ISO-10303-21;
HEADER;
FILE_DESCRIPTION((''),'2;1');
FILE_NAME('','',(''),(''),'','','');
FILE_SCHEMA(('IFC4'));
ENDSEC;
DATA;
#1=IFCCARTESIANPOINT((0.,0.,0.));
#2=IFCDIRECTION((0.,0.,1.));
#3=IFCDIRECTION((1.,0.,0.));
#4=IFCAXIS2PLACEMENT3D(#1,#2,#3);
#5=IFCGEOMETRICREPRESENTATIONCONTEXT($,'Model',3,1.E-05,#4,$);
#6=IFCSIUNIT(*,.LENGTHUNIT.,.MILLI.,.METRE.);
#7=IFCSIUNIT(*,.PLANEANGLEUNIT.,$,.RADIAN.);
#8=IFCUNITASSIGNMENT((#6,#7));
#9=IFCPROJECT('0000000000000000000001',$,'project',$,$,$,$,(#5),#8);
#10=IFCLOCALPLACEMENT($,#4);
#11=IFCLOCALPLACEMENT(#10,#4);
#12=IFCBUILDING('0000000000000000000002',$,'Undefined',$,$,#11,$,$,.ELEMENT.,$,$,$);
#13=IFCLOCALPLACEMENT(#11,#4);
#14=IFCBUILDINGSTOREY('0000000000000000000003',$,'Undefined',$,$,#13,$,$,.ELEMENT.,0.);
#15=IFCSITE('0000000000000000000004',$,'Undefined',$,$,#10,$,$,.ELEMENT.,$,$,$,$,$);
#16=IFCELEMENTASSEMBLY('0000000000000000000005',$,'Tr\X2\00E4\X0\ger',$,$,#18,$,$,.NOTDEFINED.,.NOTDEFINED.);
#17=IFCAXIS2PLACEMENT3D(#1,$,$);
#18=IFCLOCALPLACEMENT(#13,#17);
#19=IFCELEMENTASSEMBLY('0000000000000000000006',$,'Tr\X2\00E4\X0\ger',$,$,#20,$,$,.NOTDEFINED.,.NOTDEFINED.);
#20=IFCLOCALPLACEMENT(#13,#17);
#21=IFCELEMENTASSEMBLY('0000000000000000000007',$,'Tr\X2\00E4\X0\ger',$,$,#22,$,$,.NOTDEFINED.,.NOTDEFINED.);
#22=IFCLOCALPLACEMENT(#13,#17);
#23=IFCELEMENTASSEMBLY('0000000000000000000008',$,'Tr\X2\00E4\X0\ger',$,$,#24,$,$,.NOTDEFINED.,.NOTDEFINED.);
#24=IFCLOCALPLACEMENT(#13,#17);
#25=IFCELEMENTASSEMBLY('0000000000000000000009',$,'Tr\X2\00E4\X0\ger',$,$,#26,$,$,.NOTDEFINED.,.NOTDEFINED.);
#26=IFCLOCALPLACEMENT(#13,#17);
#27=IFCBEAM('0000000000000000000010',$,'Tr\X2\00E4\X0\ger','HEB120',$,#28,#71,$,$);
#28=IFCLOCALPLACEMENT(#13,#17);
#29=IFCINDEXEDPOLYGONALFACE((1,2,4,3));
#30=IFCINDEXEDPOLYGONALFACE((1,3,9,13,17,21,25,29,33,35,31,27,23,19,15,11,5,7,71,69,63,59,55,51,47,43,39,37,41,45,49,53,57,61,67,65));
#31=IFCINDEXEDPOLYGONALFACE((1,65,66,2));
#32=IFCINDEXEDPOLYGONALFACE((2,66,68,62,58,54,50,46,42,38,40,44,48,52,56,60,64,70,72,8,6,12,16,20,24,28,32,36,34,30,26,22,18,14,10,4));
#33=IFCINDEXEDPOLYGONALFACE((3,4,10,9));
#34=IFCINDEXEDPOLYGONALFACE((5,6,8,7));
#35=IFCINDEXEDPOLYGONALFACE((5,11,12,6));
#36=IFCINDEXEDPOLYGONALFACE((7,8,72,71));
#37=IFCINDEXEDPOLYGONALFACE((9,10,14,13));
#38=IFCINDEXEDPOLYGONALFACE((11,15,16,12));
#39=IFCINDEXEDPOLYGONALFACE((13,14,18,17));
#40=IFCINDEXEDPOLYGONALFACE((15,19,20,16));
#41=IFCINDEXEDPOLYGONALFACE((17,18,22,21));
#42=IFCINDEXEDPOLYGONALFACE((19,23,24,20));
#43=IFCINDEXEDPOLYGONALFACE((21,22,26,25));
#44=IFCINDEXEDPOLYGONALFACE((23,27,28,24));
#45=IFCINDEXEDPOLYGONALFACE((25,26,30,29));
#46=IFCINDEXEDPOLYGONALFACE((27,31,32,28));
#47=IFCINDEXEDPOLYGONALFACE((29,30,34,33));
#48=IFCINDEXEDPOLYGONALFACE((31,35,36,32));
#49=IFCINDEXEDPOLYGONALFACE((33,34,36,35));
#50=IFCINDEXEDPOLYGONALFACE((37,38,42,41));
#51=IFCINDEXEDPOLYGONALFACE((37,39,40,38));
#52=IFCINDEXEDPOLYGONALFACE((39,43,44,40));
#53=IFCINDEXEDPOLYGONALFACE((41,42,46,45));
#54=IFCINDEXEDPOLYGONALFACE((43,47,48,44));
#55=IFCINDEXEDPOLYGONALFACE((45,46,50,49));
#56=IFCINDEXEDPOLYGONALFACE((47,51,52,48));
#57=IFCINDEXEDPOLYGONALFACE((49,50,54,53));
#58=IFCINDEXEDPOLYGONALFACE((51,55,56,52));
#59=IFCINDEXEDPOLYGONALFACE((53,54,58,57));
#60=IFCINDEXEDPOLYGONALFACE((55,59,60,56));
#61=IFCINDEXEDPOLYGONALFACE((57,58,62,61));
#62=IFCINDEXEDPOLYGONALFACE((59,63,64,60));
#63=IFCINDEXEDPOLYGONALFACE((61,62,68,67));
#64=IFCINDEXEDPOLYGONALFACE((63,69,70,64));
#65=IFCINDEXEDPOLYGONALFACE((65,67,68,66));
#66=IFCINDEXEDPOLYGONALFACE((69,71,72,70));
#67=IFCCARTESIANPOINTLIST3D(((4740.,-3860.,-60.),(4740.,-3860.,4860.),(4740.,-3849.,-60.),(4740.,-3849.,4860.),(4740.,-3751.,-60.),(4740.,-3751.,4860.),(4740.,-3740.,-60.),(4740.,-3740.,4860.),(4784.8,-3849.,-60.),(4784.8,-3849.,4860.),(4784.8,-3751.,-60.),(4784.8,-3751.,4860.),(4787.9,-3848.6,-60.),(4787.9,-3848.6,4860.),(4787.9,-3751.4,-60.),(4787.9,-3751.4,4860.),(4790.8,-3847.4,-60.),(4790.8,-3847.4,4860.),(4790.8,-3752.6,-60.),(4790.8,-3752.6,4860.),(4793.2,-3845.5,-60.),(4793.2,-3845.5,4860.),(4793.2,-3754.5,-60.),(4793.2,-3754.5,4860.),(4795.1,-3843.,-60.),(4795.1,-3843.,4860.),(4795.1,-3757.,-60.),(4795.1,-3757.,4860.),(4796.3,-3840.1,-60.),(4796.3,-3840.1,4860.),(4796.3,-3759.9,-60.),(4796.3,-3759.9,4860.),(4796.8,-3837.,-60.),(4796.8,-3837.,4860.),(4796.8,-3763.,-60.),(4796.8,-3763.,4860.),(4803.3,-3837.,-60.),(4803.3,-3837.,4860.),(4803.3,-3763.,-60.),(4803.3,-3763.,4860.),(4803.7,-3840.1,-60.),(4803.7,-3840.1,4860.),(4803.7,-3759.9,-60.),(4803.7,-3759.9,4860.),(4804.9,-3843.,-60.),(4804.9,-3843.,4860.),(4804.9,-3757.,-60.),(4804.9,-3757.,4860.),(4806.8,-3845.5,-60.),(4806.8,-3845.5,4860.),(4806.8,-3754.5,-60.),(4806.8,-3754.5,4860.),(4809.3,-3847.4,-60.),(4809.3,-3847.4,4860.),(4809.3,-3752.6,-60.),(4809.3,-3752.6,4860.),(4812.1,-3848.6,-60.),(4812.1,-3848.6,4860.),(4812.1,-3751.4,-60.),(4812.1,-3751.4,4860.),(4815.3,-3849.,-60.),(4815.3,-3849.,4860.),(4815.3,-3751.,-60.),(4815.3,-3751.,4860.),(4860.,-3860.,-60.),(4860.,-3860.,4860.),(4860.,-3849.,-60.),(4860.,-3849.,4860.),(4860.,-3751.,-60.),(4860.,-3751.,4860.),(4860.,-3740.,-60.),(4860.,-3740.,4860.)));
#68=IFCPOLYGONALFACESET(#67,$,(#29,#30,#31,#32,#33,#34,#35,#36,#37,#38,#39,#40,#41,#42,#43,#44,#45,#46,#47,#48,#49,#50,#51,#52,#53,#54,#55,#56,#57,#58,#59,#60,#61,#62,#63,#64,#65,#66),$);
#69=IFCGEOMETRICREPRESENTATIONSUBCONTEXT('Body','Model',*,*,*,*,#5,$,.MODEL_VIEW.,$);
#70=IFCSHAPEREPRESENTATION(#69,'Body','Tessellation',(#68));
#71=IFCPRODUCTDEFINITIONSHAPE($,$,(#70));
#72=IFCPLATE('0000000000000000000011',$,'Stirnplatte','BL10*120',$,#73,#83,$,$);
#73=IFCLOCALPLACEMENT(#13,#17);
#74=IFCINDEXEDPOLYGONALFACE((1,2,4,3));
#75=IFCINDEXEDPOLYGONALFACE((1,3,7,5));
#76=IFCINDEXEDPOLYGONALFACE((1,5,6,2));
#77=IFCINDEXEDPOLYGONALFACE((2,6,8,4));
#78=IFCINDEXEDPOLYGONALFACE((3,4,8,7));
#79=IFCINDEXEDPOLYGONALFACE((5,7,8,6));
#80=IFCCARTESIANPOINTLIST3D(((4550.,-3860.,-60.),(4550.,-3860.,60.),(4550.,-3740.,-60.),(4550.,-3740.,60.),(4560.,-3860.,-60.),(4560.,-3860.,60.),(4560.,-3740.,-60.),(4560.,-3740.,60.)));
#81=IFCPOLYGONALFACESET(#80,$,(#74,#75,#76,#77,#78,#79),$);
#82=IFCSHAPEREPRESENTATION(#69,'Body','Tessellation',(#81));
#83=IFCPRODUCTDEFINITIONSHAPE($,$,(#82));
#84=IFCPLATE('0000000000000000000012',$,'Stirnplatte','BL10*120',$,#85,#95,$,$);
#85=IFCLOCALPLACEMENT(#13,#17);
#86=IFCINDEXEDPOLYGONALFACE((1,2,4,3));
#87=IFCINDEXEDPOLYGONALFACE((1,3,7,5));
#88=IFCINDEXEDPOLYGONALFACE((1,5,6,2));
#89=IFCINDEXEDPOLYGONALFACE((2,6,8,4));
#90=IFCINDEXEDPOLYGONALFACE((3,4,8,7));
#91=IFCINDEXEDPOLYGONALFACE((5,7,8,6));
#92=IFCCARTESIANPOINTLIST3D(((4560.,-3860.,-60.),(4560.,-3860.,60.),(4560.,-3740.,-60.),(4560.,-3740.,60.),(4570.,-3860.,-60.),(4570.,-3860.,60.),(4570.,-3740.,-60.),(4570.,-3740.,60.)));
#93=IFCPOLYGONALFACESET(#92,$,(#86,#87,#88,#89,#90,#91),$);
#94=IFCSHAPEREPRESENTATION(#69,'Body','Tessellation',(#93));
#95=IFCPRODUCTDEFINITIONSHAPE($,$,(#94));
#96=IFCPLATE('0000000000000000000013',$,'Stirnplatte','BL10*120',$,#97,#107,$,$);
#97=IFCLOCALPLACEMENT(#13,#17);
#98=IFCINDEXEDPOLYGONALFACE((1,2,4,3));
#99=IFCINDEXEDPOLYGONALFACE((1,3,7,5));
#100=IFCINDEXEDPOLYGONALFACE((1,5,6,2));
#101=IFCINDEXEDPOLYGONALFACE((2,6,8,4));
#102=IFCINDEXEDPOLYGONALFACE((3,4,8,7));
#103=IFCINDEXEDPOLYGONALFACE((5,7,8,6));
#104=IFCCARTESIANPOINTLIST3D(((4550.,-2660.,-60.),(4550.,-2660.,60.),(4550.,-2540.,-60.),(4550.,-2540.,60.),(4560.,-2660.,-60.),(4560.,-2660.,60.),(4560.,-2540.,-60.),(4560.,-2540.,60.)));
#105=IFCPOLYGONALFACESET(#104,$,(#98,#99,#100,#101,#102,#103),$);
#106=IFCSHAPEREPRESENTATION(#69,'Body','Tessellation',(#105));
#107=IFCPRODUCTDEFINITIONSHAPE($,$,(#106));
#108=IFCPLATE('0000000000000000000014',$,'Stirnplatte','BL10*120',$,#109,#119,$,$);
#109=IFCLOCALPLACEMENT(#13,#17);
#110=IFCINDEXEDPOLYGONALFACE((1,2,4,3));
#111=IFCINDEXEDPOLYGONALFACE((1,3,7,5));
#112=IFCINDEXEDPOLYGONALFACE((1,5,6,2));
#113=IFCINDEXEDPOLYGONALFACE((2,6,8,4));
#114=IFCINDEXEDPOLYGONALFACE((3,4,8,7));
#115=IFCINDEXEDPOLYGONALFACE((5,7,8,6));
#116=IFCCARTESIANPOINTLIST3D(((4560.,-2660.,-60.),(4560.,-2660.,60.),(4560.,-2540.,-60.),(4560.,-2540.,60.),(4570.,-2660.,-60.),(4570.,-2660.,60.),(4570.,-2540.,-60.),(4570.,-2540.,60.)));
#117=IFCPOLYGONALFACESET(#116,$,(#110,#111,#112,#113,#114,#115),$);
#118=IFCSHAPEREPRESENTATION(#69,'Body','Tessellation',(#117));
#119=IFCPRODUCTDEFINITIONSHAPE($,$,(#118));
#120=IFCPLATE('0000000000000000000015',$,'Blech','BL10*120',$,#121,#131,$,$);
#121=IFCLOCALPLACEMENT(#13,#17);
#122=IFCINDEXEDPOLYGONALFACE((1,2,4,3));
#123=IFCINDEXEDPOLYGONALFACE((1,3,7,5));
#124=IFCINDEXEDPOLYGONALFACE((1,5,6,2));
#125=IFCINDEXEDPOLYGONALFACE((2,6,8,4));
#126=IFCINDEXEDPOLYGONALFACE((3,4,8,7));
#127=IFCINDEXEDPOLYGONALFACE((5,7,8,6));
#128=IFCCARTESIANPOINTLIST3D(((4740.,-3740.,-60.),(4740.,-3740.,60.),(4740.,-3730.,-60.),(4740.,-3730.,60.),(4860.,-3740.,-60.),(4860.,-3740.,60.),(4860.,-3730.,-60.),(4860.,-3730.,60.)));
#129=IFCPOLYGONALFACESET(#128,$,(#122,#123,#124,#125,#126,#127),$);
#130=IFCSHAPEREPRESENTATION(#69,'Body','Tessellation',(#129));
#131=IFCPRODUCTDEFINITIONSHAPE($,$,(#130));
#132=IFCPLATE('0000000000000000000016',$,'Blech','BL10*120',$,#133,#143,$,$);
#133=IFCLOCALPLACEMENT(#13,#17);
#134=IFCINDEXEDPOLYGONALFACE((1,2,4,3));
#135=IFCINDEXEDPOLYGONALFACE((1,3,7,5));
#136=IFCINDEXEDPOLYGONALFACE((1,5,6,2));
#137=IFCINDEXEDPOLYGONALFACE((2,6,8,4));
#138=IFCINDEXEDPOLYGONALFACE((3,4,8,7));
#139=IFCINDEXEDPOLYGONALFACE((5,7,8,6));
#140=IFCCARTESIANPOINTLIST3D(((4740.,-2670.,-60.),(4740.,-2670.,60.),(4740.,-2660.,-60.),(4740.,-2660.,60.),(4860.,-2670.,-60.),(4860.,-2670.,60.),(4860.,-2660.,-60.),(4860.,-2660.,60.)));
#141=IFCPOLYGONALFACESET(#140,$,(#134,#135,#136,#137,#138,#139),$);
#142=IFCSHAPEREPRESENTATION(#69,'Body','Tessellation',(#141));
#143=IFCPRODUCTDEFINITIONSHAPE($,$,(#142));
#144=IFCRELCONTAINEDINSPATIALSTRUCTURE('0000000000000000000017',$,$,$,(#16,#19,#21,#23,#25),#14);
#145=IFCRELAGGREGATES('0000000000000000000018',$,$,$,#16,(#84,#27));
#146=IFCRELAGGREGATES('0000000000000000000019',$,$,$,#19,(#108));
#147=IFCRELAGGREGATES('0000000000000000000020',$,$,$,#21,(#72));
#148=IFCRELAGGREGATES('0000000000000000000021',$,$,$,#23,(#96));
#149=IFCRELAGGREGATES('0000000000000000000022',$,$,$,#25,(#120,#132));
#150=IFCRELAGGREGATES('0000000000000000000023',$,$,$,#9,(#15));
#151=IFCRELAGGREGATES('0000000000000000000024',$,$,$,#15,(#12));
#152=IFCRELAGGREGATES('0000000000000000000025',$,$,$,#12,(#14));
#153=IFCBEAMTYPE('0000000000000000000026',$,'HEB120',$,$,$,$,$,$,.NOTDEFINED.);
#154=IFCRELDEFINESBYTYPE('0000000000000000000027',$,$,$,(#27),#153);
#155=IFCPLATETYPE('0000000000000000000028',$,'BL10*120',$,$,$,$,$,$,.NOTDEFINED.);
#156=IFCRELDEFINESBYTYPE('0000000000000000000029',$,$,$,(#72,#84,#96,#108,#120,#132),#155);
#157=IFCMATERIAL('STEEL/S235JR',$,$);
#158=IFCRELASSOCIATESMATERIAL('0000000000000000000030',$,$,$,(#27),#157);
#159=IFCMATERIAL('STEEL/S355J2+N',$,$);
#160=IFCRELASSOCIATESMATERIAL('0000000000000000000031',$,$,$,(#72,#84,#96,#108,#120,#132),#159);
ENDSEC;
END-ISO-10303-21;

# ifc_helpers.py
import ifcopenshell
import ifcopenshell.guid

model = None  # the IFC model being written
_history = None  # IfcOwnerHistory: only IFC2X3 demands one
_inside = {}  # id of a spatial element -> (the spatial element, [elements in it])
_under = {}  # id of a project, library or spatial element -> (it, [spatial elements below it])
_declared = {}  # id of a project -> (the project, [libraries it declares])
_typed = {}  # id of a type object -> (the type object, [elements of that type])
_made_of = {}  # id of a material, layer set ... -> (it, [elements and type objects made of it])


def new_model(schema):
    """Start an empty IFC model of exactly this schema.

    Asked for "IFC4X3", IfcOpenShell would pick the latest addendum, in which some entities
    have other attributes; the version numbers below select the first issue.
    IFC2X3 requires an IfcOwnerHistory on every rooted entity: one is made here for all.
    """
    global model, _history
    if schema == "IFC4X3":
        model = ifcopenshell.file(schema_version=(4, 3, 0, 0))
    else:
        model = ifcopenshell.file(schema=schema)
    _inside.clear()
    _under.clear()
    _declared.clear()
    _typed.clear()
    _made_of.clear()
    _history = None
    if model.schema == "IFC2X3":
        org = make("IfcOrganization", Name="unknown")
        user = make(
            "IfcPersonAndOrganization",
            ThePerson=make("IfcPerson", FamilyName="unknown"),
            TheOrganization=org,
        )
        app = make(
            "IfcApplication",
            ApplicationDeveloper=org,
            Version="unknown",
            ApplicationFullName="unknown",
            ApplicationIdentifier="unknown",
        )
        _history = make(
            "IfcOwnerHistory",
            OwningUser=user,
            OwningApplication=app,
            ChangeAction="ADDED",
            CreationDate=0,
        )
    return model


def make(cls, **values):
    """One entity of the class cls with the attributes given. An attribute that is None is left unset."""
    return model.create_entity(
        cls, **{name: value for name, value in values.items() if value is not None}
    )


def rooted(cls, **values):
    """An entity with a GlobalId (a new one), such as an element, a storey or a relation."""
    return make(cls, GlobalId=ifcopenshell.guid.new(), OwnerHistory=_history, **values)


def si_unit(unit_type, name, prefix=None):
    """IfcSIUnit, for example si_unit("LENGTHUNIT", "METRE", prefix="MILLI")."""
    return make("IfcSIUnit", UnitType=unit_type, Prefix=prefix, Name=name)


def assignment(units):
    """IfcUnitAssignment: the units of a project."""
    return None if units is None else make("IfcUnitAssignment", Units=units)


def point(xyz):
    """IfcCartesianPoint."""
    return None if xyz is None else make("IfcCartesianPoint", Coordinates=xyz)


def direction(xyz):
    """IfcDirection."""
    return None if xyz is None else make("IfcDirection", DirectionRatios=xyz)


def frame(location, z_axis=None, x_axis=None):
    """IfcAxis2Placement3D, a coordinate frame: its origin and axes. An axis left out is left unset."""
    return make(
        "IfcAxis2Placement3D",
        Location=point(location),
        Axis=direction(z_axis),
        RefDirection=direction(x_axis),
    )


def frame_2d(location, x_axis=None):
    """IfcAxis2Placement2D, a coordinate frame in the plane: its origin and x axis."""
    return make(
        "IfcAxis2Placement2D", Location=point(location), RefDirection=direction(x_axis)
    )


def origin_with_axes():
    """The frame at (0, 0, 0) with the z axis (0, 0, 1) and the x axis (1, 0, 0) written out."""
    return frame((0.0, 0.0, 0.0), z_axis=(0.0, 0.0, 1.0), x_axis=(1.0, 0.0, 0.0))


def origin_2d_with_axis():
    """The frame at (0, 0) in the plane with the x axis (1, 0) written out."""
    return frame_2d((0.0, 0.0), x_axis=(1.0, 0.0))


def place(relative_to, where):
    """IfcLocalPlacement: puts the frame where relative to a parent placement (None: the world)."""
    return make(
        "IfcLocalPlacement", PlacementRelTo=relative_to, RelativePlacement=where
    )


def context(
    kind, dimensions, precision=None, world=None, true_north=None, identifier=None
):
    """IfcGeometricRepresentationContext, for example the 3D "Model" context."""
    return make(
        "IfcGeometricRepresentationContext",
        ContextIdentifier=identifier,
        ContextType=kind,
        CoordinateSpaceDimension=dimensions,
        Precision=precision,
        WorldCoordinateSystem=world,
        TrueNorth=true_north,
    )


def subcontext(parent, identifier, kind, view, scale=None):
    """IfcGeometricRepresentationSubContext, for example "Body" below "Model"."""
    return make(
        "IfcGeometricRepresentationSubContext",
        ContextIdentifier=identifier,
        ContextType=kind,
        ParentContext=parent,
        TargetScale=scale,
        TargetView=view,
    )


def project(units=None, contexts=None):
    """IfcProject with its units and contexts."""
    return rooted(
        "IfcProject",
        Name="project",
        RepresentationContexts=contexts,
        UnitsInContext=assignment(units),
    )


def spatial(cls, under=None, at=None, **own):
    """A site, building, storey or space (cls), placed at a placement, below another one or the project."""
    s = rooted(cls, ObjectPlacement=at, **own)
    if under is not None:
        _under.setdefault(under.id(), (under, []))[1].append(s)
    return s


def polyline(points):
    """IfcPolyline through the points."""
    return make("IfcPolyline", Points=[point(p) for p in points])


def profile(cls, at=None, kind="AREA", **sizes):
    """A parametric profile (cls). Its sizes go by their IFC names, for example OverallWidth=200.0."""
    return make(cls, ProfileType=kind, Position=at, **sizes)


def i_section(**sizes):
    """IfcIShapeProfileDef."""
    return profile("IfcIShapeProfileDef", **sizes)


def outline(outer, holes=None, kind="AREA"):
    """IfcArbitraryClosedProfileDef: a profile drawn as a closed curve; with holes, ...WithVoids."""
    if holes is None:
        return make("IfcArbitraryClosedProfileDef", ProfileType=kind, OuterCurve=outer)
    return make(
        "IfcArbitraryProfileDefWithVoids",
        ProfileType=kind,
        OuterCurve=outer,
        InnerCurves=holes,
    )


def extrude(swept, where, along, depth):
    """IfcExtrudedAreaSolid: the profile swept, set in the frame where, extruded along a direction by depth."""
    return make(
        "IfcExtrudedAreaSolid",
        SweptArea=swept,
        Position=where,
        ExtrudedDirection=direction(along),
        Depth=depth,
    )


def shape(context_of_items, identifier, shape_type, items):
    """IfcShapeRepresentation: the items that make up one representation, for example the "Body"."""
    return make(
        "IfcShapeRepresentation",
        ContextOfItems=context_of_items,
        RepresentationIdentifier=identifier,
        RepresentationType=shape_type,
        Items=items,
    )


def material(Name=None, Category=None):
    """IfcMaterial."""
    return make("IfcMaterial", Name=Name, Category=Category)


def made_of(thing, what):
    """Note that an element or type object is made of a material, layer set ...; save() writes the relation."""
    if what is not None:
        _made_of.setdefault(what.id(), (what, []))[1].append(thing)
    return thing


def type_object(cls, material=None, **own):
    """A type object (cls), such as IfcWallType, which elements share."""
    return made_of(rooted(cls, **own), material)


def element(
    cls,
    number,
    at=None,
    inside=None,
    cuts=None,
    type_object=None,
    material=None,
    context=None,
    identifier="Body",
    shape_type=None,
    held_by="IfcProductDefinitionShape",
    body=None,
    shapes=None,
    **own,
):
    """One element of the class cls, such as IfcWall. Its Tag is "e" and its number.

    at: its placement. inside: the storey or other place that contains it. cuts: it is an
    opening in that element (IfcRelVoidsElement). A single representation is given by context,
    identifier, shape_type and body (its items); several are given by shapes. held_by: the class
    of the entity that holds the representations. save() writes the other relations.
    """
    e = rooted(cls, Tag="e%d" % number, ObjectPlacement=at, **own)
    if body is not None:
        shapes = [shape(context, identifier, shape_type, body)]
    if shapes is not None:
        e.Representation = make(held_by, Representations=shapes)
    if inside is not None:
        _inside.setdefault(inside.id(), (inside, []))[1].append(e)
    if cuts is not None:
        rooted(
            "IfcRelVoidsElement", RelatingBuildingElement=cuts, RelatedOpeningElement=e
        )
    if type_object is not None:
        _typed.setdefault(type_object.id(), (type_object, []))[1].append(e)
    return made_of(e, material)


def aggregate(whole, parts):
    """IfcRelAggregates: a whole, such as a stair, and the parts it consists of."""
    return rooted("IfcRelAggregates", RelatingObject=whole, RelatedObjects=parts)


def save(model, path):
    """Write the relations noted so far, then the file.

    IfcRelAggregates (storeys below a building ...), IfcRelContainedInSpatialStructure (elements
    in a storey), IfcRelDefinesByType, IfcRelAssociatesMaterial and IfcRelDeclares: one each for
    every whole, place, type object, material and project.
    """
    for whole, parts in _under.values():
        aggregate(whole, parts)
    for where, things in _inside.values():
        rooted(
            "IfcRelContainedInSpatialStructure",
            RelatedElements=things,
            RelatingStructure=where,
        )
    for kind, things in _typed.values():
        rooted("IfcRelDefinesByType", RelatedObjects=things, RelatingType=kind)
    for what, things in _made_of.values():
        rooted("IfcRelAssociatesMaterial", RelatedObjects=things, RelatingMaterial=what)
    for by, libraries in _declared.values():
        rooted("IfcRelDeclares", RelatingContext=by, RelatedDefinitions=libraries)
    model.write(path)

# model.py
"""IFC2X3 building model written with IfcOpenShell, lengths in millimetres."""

from ifc_helpers import new_model, si_unit, frame, origin_with_axes, origin_2d_with_axis, place, context, subcontext, project, spatial, polyline, i_section, outline, extrude, material, type_object, element, aggregate, save


model = new_model("IFC2X3")

# Units and contexts
model_context = context("Model", 3, precision=1e-05, world=origin_with_axes())
body_context = subcontext(model_context, "Body", "Model", "MODEL_VIEW")
ifc_project = project(units=[si_unit("LENGTHUNIT", "METRE", prefix="MILLI"), si_unit("PLANEANGLEUNIT", "RADIAN")], contexts=[model_context])

# Site, building, storey
site_placement = place(None, origin_with_axes())
site = spatial("IfcSite", under=ifc_project, at=site_placement, Name="Undefined", CompositionType="ELEMENT")
building_placement = place(site_placement, origin_with_axes())
building = spatial("IfcBuilding", under=site, at=building_placement, Name="Undefined", CompositionType="ELEMENT")
storey_placement = place(building_placement, origin_with_axes())
storey = spatial("IfcBuildingStorey", under=building, at=storey_placement, Name="Undefined", CompositionType="ELEMENT", Elevation=0.0)

# Shared definitions
ifc_material_1 = material(Name="STEEL/S235JR")

# Element assemblies
assembly_1_placement = place(storey_placement, origin_with_axes())
assembly_1 = element("IfcElementAssembly", 1, at=assembly_1_placement, inside=storey, Name="Träger", AssemblyPlace="NOTDEFINED", PredefinedType="NOTDEFINED")
beam_type = type_object("IfcBeamType", Name="HEB120", PredefinedType="NOTDEFINED")
assembly_2_placement = place(storey_placement, origin_with_axes())
assembly_2 = element("IfcElementAssembly", 2, at=assembly_2_placement, inside=storey, Name="Träger", AssemblyPlace="NOTDEFINED", PredefinedType="NOTDEFINED")
assembly_3_placement = place(storey_placement, origin_with_axes())
assembly_3 = element("IfcElementAssembly", 3, at=assembly_3_placement, inside=storey, Name="Träger", AssemblyPlace="NOTDEFINED", PredefinedType="NOTDEFINED")
assembly_4_placement = place(storey_placement, origin_with_axes())
assembly_4 = element("IfcElementAssembly", 4, at=assembly_4_placement, inside=storey, Name="Träger", AssemblyPlace="NOTDEFINED", PredefinedType="NOTDEFINED")
assembly_5_placement = place(storey_placement, origin_with_axes())
assembly_5 = element("IfcElementAssembly", 5, at=assembly_5_placement, inside=storey, Name="Träger", AssemblyPlace="NOTDEFINED", PredefinedType="NOTDEFINED")

# Beam
beam_1_placement = place(assembly_1_placement, frame((4800.0, -3800.0, -60.0), z_axis=(0.0, 1.0, 0.0), x_axis=(0.0, 0.0, 1.0)))
beam_1 = element("IfcBeam", 6, at=beam_1_placement, type_object=beam_type, material=ifc_material_1, Name="Träger", Description="HEB120", context=body_context, shape_type="SweptSolid", body=[
    extrude(i_section(OverallWidth=120.0, OverallDepth=120.0, WebThickness=6.5, FlangeThickness=11.0, FilletRadius=12.0, at=origin_2d_with_axis()), frame((4920.0, 0.0, 0.0), z_axis=(-1.0, 0.0, 0.0), x_axis=(0.0, -1.0, 0.0)), (0.0, 0.0, 1.0), 4920.0),
])

# Plates
ifc_material_2 = material(Name="STEEL/S355J2+N")
plate_type = type_object("IfcPlateType", Name="BL10*120", PredefinedType="NOTDEFINED")
plate_1_placement = place(assembly_3_placement, frame((4555.0, -3800.0, -60.0), z_axis=(-1.0, 0.0, 0.0), x_axis=(0.0, 0.0, 1.0)))
plate_1 = element("IfcPlate", 7, at=plate_1_placement, type_object=plate_type, material=ifc_material_2, Name="Stirnplatte", Description="BL10*120", context=body_context, shape_type="SweptSolid", body=[
    extrude(outline(polyline([(0.0, -60.0), (0.0, 60.0), (120.0, 60.0), (120.0, -60.0), (0.0, -60.0)])), frame((0.0, 0.0, -5.0), z_axis=(0.0, 0.0, 1.0), x_axis=(1.0, 0.0, 0.0)), (0.0, 0.0, 1.0), 10.0),
])
plate_2_placement = place(assembly_1_placement, frame((4565.0, -3800.0, -60.0), z_axis=(-1.0, 0.0, 0.0), x_axis=(0.0, 0.0, 1.0)))
plate_2 = element("IfcPlate", 8, at=plate_2_placement, type_object=plate_type, material=ifc_material_2, Name="Stirnplatte", Description="BL10*120", context=body_context, shape_type="SweptSolid", body=[
    extrude(outline(polyline([(0.0, -60.0), (0.0, 60.0), (120.0, 60.0), (120.0, -60.0), (0.0, -60.0)])), frame((0.0, 0.0, -5.0), z_axis=(0.0, 0.0, 1.0), x_axis=(1.0, 0.0, 0.0)), (0.0, 0.0, 1.0), 10.0),
])
aggregate(assembly_1, [plate_2, beam_1])
plate_3_placement = place(assembly_4_placement, frame((4555.0, -2600.0, -60.0), z_axis=(-1.0, 0.0, 0.0), x_axis=(0.0, 0.0, 1.0)))
plate_3 = element("IfcPlate", 9, at=plate_3_placement, type_object=plate_type, material=ifc_material_2, Name="Stirnplatte", Description="BL10*120", context=body_context, shape_type="SweptSolid", body=[
    extrude(outline(polyline([(0.0, -60.0), (0.0, 60.0), (120.0, 60.0), (120.0, -60.0), (0.0, -60.0)])), frame((0.0, 0.0, -5.0), z_axis=(0.0, 0.0, 1.0), x_axis=(1.0, 0.0, 0.0)), (0.0, 0.0, 1.0), 10.0),
])
plate_4_placement = place(assembly_2_placement, frame((4565.0, -2600.0, -60.0), z_axis=(-1.0, 0.0, 0.0), x_axis=(0.0, 0.0, 1.0)))
plate_4 = element("IfcPlate", 10, at=plate_4_placement, type_object=plate_type, material=ifc_material_2, Name="Stirnplatte", Description="BL10*120", context=body_context, shape_type="SweptSolid", body=[
    extrude(outline(polyline([(0.0, -60.0), (0.0, 60.0), (120.0, 60.0), (120.0, -60.0), (0.0, -60.0)])), frame((0.0, 0.0, -5.0), z_axis=(0.0, 0.0, 1.0), x_axis=(1.0, 0.0, 0.0)), (0.0, 0.0, 1.0), 10.0),
])
aggregate(assembly_2, [plate_4])
plate_5_placement = place(assembly_5_placement, frame((4800.0, -3735.0, -60.0), z_axis=(0.0, 1.0, 0.0), x_axis=(0.0, 0.0, 1.0)))
plate_5 = element("IfcPlate", 11, at=plate_5_placement, type_object=plate_type, material=ifc_material_2, Name="Blech", Description="BL10*120", context=body_context, shape_type="SweptSolid", body=[
    extrude(outline(polyline([(0.0, -60.0), (0.0, 60.0), (120.0, 60.0), (120.0, -60.0), (0.0, -60.0)])), frame((0.0, 0.0, -5.0), z_axis=(0.0, 0.0, 1.0), x_axis=(1.0, 0.0, 0.0)), (0.0, 0.0, 1.0), 10.0),
])
plate_6_placement = place(assembly_5_placement, frame((4800.0, -2665.0, -60.0), z_axis=(0.0, -1.0, 0.0), x_axis=(0.0, 0.0, 1.0)))
plate_6 = element("IfcPlate", 12, at=plate_6_placement, type_object=plate_type, material=ifc_material_2, Name="Blech", Description="BL10*120", context=body_context, shape_type="SweptSolid", body=[
    extrude(outline(polyline([(0.0, -60.0), (0.0, 60.0), (120.0, 60.0), (120.0, -60.0), (0.0, -60.0)])), frame((0.0, 0.0, -5.0), z_axis=(0.0, 0.0, 1.0), x_axis=(1.0, 0.0, 0.0)), (0.0, 0.0, 1.0), 10.0),
])

aggregate(assembly_3, [plate_1])
aggregate(assembly_4, [plate_3])
aggregate(assembly_5, [plate_5, plate_6])

save(model, "model.ifc")
